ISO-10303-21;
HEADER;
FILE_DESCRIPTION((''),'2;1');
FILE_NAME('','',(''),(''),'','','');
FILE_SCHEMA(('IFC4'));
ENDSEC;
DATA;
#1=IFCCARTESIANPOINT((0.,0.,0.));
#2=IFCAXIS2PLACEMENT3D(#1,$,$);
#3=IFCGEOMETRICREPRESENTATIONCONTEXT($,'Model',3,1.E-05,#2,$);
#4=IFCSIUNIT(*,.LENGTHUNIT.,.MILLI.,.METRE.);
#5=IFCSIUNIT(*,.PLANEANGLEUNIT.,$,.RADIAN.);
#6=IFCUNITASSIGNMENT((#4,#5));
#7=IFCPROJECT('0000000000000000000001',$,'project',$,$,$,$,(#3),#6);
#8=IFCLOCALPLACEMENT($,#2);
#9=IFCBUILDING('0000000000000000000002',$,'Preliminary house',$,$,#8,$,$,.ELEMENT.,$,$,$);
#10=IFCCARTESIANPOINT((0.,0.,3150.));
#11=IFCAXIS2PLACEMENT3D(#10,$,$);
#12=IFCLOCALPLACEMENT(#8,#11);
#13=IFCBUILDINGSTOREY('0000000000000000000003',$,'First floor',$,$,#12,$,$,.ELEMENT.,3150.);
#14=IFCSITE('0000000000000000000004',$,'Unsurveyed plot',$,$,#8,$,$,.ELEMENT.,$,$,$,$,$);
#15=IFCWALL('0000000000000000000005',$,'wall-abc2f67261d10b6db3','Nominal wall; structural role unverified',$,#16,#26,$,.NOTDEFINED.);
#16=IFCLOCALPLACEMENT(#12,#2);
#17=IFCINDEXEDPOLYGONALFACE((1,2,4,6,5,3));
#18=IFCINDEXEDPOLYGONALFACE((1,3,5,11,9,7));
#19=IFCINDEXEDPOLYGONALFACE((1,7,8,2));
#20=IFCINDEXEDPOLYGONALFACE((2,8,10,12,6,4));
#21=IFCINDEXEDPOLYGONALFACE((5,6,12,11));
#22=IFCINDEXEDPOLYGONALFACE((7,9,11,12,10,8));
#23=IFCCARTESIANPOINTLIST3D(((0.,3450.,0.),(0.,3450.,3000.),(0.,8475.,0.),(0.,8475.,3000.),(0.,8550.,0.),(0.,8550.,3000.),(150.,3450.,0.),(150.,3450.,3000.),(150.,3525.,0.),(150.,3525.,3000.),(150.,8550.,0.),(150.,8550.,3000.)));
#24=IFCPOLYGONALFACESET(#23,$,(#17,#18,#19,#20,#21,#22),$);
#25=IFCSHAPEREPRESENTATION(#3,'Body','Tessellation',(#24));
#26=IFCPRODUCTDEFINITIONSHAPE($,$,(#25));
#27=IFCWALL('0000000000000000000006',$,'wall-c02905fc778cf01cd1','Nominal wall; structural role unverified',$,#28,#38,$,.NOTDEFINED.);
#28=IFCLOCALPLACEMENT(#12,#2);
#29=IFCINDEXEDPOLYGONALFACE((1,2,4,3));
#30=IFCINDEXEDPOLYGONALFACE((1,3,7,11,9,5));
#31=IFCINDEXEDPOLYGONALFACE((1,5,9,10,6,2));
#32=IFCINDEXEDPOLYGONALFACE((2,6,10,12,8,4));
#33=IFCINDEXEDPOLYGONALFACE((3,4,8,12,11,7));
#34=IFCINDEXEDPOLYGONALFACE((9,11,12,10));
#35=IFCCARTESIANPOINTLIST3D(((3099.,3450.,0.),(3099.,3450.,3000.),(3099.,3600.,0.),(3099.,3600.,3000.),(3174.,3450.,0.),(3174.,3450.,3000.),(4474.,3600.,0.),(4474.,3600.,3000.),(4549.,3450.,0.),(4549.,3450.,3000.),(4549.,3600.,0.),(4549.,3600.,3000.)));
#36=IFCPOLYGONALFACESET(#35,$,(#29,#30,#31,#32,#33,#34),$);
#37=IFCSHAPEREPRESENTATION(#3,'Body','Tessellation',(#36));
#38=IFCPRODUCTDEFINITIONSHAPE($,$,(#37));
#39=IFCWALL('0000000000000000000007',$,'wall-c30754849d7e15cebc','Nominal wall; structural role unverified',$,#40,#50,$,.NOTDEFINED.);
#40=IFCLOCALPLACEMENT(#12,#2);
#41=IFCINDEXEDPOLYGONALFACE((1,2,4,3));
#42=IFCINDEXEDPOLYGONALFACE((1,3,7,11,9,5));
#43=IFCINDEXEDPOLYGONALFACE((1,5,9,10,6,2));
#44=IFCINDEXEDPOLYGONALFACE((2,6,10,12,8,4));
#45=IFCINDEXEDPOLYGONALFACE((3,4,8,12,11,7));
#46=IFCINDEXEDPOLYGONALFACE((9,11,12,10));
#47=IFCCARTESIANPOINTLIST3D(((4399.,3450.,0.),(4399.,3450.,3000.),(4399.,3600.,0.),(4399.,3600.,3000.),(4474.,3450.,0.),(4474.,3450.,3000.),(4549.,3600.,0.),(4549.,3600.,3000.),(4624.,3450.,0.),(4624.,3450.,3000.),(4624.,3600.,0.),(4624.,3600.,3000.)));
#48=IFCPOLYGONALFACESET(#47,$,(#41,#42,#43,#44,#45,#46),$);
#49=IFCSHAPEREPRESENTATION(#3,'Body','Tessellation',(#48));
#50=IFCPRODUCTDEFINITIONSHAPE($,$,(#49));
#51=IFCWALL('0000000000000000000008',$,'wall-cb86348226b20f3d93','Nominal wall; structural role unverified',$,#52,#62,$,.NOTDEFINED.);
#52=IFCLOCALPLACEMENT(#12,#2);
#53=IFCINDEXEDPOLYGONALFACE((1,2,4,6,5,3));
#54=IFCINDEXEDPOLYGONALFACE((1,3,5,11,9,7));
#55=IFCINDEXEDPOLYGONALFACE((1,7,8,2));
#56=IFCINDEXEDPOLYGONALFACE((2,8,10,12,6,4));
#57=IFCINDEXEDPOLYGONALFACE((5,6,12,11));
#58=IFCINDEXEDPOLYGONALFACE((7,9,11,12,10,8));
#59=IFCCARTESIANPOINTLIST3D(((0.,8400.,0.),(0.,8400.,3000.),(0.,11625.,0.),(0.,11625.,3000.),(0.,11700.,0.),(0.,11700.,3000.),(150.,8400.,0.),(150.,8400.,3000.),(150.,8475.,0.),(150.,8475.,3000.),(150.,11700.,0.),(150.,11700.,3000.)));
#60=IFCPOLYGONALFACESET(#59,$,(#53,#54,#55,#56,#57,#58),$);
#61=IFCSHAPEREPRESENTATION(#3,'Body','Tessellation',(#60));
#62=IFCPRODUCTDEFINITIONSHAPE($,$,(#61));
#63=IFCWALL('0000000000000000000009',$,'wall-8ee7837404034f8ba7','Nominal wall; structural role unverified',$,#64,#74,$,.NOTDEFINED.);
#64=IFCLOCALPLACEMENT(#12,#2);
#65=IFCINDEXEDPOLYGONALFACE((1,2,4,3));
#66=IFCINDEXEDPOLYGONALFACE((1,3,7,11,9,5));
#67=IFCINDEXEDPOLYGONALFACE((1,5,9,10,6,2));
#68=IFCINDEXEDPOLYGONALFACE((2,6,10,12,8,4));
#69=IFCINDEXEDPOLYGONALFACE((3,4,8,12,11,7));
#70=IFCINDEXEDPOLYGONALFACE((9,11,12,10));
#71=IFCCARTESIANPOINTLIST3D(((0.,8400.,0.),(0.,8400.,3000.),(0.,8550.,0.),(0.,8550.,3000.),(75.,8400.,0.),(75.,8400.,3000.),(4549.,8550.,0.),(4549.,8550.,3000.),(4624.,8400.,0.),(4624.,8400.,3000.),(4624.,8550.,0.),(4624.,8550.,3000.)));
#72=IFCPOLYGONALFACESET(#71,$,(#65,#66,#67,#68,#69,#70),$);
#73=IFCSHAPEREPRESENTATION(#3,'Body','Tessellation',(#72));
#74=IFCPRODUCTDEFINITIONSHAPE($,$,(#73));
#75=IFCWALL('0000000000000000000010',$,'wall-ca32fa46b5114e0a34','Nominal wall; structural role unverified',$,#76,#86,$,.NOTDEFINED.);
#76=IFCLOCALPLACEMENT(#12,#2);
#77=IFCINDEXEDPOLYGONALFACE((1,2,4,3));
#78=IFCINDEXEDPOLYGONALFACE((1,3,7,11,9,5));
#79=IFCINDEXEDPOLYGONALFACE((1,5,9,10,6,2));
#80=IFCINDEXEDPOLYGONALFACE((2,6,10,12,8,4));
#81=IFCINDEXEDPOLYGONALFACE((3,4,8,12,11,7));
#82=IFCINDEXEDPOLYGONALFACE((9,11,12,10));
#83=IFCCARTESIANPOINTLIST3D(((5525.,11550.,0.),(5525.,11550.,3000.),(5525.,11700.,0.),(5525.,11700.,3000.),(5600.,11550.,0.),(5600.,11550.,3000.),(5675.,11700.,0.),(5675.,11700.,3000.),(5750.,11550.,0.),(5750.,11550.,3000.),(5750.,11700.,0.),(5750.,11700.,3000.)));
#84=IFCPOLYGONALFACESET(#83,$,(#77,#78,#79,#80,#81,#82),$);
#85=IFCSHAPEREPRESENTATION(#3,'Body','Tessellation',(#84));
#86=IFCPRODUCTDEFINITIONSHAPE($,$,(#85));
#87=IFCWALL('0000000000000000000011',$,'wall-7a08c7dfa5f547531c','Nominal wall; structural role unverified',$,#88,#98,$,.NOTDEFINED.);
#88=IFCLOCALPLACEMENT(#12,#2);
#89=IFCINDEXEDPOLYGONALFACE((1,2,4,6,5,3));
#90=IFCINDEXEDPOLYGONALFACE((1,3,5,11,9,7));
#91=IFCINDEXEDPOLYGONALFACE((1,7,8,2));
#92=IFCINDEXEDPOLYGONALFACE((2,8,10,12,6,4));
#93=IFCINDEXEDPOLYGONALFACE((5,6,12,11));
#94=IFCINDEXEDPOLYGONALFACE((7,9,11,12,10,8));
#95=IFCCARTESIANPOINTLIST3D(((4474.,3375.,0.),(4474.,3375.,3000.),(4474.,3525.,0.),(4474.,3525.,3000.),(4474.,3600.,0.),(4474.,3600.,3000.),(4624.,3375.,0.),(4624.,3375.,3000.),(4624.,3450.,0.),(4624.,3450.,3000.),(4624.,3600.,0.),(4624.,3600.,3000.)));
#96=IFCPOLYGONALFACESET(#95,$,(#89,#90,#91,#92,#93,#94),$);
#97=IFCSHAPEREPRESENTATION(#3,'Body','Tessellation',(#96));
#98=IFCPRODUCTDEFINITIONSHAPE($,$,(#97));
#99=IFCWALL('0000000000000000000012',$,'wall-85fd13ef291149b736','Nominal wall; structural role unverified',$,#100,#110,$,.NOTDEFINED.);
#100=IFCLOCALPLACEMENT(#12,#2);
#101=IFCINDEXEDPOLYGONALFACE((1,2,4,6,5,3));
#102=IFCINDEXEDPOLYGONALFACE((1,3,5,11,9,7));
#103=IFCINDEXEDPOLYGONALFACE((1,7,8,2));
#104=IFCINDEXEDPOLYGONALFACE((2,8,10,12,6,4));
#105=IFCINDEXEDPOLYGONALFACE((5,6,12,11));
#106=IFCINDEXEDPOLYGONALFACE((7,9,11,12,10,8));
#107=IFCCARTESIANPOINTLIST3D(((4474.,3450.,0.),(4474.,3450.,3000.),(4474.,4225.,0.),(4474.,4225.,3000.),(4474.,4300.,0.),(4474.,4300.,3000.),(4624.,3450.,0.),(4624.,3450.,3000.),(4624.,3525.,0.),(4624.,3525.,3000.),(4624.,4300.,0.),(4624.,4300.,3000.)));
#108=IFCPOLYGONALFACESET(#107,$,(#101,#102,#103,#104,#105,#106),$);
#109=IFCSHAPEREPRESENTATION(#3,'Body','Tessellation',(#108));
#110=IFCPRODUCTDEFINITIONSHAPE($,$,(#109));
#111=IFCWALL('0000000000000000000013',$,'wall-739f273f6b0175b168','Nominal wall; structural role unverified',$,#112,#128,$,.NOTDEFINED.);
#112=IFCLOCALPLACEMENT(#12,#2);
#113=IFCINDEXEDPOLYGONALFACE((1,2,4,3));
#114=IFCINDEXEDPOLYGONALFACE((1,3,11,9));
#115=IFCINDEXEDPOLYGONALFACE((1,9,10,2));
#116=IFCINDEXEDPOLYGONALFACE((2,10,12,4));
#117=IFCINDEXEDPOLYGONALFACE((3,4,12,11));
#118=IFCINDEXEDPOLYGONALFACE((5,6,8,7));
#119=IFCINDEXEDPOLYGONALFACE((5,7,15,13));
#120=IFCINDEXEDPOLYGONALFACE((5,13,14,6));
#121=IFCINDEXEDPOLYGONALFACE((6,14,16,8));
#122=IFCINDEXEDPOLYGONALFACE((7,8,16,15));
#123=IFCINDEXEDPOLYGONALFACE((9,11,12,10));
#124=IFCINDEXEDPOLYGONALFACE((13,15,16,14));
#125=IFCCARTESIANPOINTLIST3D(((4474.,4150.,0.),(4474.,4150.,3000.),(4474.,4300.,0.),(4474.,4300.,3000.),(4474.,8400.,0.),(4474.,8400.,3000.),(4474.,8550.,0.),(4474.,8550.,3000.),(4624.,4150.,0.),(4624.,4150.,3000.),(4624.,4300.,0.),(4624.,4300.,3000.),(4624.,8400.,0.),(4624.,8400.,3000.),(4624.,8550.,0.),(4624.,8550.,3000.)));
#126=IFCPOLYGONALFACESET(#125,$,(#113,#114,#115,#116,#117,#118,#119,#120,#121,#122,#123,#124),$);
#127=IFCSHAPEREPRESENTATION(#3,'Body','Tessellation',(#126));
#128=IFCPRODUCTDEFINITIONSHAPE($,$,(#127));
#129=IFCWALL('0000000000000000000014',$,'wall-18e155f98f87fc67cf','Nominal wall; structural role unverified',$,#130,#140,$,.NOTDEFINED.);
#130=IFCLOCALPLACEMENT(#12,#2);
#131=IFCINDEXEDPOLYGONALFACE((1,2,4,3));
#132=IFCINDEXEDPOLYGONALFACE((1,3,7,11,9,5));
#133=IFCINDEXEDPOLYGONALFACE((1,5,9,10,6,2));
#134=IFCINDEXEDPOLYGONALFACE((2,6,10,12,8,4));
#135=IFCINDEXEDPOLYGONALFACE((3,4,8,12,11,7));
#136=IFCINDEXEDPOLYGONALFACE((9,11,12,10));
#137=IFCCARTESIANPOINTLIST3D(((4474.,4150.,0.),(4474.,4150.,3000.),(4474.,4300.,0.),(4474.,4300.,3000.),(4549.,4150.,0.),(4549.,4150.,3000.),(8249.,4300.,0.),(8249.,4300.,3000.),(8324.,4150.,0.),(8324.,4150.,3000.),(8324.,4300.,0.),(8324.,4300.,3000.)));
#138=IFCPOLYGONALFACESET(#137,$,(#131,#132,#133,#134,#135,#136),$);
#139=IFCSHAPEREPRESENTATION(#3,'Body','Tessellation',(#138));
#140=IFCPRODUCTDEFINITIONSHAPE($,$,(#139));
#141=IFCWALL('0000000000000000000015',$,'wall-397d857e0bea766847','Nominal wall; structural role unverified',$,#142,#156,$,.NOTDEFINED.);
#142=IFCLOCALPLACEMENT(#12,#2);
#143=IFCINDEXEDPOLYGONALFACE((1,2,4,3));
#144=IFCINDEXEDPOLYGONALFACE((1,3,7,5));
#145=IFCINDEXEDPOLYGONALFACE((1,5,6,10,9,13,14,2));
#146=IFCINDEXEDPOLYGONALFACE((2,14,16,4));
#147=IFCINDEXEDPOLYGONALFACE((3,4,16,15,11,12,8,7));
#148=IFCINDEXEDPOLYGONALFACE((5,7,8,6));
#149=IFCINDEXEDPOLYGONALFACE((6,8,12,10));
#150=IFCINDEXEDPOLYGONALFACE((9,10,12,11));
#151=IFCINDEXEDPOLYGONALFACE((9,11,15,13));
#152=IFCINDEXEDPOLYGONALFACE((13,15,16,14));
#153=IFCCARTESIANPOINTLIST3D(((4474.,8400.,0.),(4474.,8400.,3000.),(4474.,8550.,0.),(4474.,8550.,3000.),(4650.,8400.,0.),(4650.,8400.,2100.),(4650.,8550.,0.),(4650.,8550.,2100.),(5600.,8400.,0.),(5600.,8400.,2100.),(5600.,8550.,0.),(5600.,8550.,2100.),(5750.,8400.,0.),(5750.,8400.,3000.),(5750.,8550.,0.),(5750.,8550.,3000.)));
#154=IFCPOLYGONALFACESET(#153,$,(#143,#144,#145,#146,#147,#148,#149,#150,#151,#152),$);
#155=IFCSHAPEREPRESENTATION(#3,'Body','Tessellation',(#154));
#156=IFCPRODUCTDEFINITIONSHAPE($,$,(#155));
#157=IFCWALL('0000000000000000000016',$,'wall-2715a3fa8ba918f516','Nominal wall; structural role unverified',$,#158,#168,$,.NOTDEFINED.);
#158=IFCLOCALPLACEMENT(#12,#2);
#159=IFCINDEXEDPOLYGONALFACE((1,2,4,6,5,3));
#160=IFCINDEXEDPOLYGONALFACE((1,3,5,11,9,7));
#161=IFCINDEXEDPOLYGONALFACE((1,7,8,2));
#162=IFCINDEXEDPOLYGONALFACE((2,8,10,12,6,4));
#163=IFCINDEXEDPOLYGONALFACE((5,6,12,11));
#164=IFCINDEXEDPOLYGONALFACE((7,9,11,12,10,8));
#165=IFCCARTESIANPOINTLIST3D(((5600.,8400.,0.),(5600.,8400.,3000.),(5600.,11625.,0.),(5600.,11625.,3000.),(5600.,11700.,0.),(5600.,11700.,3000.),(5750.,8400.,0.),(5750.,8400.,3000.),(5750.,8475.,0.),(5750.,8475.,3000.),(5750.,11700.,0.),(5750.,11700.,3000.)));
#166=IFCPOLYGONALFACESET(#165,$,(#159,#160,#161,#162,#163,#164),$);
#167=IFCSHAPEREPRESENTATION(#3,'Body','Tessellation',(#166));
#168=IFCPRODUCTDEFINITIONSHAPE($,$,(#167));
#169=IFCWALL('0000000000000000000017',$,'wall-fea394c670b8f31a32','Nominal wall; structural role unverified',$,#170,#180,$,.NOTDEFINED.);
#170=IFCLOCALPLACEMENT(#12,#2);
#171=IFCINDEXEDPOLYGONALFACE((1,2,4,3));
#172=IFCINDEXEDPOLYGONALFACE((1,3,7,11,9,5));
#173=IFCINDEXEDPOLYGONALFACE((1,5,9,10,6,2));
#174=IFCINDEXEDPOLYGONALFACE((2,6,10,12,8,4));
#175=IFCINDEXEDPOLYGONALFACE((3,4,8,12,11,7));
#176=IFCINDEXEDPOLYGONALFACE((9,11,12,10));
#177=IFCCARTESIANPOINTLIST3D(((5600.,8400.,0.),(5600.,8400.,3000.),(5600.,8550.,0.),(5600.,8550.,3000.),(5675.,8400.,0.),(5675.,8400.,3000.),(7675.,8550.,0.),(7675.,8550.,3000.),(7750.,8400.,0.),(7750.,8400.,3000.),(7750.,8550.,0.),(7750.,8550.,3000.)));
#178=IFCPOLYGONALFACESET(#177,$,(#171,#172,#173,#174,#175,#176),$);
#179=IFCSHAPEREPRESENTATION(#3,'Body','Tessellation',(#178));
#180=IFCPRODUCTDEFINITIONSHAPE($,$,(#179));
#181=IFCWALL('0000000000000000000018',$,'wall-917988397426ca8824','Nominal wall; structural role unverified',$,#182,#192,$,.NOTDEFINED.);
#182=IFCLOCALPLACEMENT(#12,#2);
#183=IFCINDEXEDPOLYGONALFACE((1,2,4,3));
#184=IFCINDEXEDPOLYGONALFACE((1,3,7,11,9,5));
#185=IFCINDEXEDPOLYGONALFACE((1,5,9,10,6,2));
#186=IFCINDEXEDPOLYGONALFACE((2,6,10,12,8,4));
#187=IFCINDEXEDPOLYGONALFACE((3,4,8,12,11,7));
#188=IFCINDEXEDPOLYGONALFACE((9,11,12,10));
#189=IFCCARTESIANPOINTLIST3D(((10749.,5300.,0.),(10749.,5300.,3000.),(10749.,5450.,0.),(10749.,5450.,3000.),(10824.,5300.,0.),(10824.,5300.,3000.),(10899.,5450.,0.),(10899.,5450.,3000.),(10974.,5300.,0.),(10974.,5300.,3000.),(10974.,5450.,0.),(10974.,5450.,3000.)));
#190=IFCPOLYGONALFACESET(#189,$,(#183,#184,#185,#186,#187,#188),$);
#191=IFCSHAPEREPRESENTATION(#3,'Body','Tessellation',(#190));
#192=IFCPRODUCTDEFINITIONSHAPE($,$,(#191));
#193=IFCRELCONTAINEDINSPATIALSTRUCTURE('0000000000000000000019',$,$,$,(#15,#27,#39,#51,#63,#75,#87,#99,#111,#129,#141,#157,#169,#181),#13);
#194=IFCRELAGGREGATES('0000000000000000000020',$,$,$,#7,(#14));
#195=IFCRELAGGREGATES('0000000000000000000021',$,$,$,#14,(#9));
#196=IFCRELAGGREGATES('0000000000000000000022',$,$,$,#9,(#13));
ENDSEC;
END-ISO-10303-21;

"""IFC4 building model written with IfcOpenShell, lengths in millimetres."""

from ifc_helpers import new_model, si_unit, frame, origin, place, context, project, spatial, polyline, outline, extrude, element, save


model = new_model("IFC4")

# Units and contexts
model_context = context("Model", 3, precision=1e-05, world=origin())
ifc_project = project(units=[si_unit("LENGTHUNIT", "METRE", prefix="MILLI"), si_unit("PLANEANGLEUNIT", "RADIAN")], contexts=[model_context])

# Site, building, storey
placement_1 = place(None, origin())
site = spatial("IfcSite", under=ifc_project, at=placement_1, Name="Unsurveyed plot", CompositionType="ELEMENT")
building = spatial("IfcBuilding", under=site, at=placement_1, Name="Preliminary house", CompositionType="ELEMENT")
placement_2 = place(placement_1, frame((0.0, 0.0, 3150.0)))
storey = spatial("IfcBuildingStorey", under=building, at=placement_2, Name="First floor", CompositionType="ELEMENT", Elevation=3150.0)

# Wall
element("IfcWall", 1, at=placement_2, inside=storey, Name="wall-abc2f67261d10b6db3", Description="Nominal wall; structural role unverified", PredefinedType="NOTDEFINED", context=model_context, shape_type="SweptSolid", body=[
    extrude(outline(polyline([(0.0, 8475.0), (0.0, 8550.0), (150.0, 8550.0), (150.0, 3525.0), (150.0, 3450.0), (0.0, 3450.0), (0.0, 8475.0)])), origin(), (0.0, 0.0, 1.0), 3000.0),
])

# Walls
element("IfcWall", 2, at=placement_2, inside=storey, Name="wall-c02905fc778cf01cd1", Description="Nominal wall; structural role unverified", PredefinedType="NOTDEFINED", context=model_context, shape_type="SweptSolid", body=[
    extrude(outline(polyline([(4474.0, 3600.0), (4549.0, 3600.0), (4549.0, 3450.0), (3174.0, 3450.0), (3099.0, 3450.0), (3099.0, 3600.0), (4474.0, 3600.0)])), origin(), (0.0, 0.0, 1.0), 3000.0),
])
element("IfcWall", 3, at=placement_2, inside=storey, Name="wall-c30754849d7e15cebc", Description="Nominal wall; structural role unverified", PredefinedType="NOTDEFINED", context=model_context, shape_type="SweptSolid", body=[
    extrude(outline(polyline([(4549.0, 3600.0), (4624.0, 3600.0), (4624.0, 3450.0), (4474.0, 3450.0), (4399.0, 3450.0), (4399.0, 3600.0), (4549.0, 3600.0)])), origin(), (0.0, 0.0, 1.0), 3000.0),
])
element("IfcWall", 4, at=placement_2, inside=storey, Name="wall-cb86348226b20f3d93", Description="Nominal wall; structural role unverified", PredefinedType="NOTDEFINED", context=model_context, shape_type="SweptSolid", body=[
    extrude(outline(polyline([(0.0, 11625.0), (0.0, 11700.0), (150.0, 11700.0), (150.0, 8475.0), (150.0, 8400.0), (0.0, 8400.0), (0.0, 11625.0)])), origin(), (0.0, 0.0, 1.0), 3000.0),
])
element("IfcWall", 5, at=placement_2, inside=storey, Name="wall-8ee7837404034f8ba7", Description="Nominal wall; structural role unverified", PredefinedType="NOTDEFINED", context=model_context, shape_type="SweptSolid", body=[
    extrude(outline(polyline([(4549.0, 8550.0), (4624.0, 8550.0), (4624.0, 8400.0), (75.0, 8400.0), (0.0, 8400.0), (0.0, 8550.0), (4549.0, 8550.0)])), origin(), (0.0, 0.0, 1.0), 3000.0),
])

# Wall
element("IfcWall", 6, at=placement_2, inside=storey, Name="wall-ca32fa46b5114e0a34", Description="Nominal wall; structural role unverified", PredefinedType="NOTDEFINED", context=model_context, shape_type="SweptSolid", body=[
    extrude(outline(polyline([(5675.0, 11700.0), (5750.0, 11700.0), (5750.0, 11550.0), (5600.0, 11550.0), (5525.0, 11550.0), (5525.0, 11700.0), (5675.0, 11700.0)])), origin(), (0.0, 0.0, 1.0), 3000.0),
])

# Wall
element("IfcWall", 7, at=placement_2, inside=storey, Name="wall-7a08c7dfa5f547531c", Description="Nominal wall; structural role unverified", PredefinedType="NOTDEFINED", context=model_context, shape_type="SweptSolid", body=[
    extrude(outline(polyline([(4474.0, 3525.0), (4474.0, 3600.0), (4624.0, 3600.0), (4624.0, 3450.0), (4624.0, 3375.0), (4474.0, 3375.0), (4474.0, 3525.0)])), origin(), (0.0, 0.0, 1.0), 3000.0),
])

# Wall
element("IfcWall", 8, at=placement_2, inside=storey, Name="wall-85fd13ef291149b736", Description="Nominal wall; structural role unverified", PredefinedType="NOTDEFINED", context=model_context, shape_type="SweptSolid", body=[
    extrude(outline(polyline([(4474.0, 4225.0), (4474.0, 4300.0), (4624.0, 4300.0), (4624.0, 3525.0), (4624.0, 3450.0), (4474.0, 3450.0), (4474.0, 4225.0)])), origin(), (0.0, 0.0, 1.0), 3000.0),
])

# Wall, opening
wall_1 = element("IfcWall", 9, at=placement_2, inside=storey, Name="wall-739f273f6b0175b168", Description="Nominal wall; structural role unverified", PredefinedType="NOTDEFINED", context=model_context, shape_type="SweptSolid", body=[
    extrude(outline(polyline([(4474.0, 8475.0), (4474.0, 8550.0), (4624.0, 8550.0), (4624.0, 4225.0), (4624.0, 4150.0), (4474.0, 4150.0), (4474.0, 8475.0)])), origin(), (0.0, 0.0, 1.0), 3000.0),
])
element("IfcOpeningElement", 10, at=placement_2, cuts=wall_1, PredefinedType="OPENING", context=model_context, shape_type="SweptSolid", body=[
    extrude(outline(polyline([(4999.0, 4300.0), (4999.0, 8400.0), (4099.0, 8400.0), (4099.0, 4300.0), (4999.0, 4300.0)])), origin(), (0.0, 0.0, 1.0), 3000.0),
])

# Wall
element("IfcWall", 11, at=placement_2, inside=storey, Name="wall-18e155f98f87fc67cf", Description="Nominal wall; structural role unverified", PredefinedType="NOTDEFINED", context=model_context, shape_type="SweptSolid", body=[
    extrude(outline(polyline([(8249.0, 4300.0), (8324.0, 4300.0), (8324.0, 4150.0), (4549.0, 4150.0), (4474.0, 4150.0), (4474.0, 4300.0), (8249.0, 4300.0)])), origin(), (0.0, 0.0, 1.0), 3000.0),
])

# Wall, opening
wall_2 = element("IfcWall", 12, at=placement_2, inside=storey, Name="wall-397d857e0bea766847", Description="Nominal wall; structural role unverified", PredefinedType="NOTDEFINED", context=model_context, shape_type="SweptSolid", body=[
    extrude(outline(polyline([(5675.0, 8550.0), (5750.0, 8550.0), (5750.0, 8400.0), (4549.0, 8400.0), (4474.0, 8400.0), (4474.0, 8550.0), (5675.0, 8550.0)])), origin(), (0.0, 0.0, 1.0), 3000.0),
])
element("IfcOpeningElement", 13, at=placement_2, cuts=wall_2, PredefinedType="OPENING", context=model_context, shape_type="SweptSolid", body=[
    extrude(outline(polyline([(4650.0, 8025.0), (5600.0, 8025.0), (5600.0, 8925.0), (4650.0, 8925.0), (4650.0, 8025.0)])), origin(), (0.0, 0.0, 1.0), 2100.0),
])

# Walls
element("IfcWall", 14, at=placement_2, inside=storey, Name="wall-2715a3fa8ba918f516", Description="Nominal wall; structural role unverified", PredefinedType="NOTDEFINED", context=model_context, shape_type="SweptSolid", body=[
    extrude(outline(polyline([(5600.0, 11625.0), (5600.0, 11700.0), (5750.0, 11700.0), (5750.0, 8475.0), (5750.0, 8400.0), (5600.0, 8400.0), (5600.0, 11625.0)])), origin(), (0.0, 0.0, 1.0), 3000.0),
])
element("IfcWall", 15, at=placement_2, inside=storey, Name="wall-fea394c670b8f31a32", Description="Nominal wall; structural role unverified", PredefinedType="NOTDEFINED", context=model_context, shape_type="SweptSolid", body=[
    extrude(outline(polyline([(7675.0, 8550.0), (7750.0, 8550.0), (7750.0, 8400.0), (5675.0, 8400.0), (5600.0, 8400.0), (5600.0, 8550.0), (7675.0, 8550.0)])), origin(), (0.0, 0.0, 1.0), 3000.0),
])
element("IfcWall", 16, at=placement_2, inside=storey, Name="wall-917988397426ca8824", Description="Nominal wall; structural role unverified", PredefinedType="NOTDEFINED", context=model_context, shape_type="SweptSolid", body=[
    extrude(outline(polyline([(10899.0, 5450.0), (10974.0, 5450.0), (10974.0, 5300.0), (10824.0, 5300.0), (10749.0, 5300.0), (10749.0, 5450.0), (10899.0, 5450.0)])), origin(), (0.0, 0.0, 1.0), 3000.0),
])

save(model, "model.ifc")
